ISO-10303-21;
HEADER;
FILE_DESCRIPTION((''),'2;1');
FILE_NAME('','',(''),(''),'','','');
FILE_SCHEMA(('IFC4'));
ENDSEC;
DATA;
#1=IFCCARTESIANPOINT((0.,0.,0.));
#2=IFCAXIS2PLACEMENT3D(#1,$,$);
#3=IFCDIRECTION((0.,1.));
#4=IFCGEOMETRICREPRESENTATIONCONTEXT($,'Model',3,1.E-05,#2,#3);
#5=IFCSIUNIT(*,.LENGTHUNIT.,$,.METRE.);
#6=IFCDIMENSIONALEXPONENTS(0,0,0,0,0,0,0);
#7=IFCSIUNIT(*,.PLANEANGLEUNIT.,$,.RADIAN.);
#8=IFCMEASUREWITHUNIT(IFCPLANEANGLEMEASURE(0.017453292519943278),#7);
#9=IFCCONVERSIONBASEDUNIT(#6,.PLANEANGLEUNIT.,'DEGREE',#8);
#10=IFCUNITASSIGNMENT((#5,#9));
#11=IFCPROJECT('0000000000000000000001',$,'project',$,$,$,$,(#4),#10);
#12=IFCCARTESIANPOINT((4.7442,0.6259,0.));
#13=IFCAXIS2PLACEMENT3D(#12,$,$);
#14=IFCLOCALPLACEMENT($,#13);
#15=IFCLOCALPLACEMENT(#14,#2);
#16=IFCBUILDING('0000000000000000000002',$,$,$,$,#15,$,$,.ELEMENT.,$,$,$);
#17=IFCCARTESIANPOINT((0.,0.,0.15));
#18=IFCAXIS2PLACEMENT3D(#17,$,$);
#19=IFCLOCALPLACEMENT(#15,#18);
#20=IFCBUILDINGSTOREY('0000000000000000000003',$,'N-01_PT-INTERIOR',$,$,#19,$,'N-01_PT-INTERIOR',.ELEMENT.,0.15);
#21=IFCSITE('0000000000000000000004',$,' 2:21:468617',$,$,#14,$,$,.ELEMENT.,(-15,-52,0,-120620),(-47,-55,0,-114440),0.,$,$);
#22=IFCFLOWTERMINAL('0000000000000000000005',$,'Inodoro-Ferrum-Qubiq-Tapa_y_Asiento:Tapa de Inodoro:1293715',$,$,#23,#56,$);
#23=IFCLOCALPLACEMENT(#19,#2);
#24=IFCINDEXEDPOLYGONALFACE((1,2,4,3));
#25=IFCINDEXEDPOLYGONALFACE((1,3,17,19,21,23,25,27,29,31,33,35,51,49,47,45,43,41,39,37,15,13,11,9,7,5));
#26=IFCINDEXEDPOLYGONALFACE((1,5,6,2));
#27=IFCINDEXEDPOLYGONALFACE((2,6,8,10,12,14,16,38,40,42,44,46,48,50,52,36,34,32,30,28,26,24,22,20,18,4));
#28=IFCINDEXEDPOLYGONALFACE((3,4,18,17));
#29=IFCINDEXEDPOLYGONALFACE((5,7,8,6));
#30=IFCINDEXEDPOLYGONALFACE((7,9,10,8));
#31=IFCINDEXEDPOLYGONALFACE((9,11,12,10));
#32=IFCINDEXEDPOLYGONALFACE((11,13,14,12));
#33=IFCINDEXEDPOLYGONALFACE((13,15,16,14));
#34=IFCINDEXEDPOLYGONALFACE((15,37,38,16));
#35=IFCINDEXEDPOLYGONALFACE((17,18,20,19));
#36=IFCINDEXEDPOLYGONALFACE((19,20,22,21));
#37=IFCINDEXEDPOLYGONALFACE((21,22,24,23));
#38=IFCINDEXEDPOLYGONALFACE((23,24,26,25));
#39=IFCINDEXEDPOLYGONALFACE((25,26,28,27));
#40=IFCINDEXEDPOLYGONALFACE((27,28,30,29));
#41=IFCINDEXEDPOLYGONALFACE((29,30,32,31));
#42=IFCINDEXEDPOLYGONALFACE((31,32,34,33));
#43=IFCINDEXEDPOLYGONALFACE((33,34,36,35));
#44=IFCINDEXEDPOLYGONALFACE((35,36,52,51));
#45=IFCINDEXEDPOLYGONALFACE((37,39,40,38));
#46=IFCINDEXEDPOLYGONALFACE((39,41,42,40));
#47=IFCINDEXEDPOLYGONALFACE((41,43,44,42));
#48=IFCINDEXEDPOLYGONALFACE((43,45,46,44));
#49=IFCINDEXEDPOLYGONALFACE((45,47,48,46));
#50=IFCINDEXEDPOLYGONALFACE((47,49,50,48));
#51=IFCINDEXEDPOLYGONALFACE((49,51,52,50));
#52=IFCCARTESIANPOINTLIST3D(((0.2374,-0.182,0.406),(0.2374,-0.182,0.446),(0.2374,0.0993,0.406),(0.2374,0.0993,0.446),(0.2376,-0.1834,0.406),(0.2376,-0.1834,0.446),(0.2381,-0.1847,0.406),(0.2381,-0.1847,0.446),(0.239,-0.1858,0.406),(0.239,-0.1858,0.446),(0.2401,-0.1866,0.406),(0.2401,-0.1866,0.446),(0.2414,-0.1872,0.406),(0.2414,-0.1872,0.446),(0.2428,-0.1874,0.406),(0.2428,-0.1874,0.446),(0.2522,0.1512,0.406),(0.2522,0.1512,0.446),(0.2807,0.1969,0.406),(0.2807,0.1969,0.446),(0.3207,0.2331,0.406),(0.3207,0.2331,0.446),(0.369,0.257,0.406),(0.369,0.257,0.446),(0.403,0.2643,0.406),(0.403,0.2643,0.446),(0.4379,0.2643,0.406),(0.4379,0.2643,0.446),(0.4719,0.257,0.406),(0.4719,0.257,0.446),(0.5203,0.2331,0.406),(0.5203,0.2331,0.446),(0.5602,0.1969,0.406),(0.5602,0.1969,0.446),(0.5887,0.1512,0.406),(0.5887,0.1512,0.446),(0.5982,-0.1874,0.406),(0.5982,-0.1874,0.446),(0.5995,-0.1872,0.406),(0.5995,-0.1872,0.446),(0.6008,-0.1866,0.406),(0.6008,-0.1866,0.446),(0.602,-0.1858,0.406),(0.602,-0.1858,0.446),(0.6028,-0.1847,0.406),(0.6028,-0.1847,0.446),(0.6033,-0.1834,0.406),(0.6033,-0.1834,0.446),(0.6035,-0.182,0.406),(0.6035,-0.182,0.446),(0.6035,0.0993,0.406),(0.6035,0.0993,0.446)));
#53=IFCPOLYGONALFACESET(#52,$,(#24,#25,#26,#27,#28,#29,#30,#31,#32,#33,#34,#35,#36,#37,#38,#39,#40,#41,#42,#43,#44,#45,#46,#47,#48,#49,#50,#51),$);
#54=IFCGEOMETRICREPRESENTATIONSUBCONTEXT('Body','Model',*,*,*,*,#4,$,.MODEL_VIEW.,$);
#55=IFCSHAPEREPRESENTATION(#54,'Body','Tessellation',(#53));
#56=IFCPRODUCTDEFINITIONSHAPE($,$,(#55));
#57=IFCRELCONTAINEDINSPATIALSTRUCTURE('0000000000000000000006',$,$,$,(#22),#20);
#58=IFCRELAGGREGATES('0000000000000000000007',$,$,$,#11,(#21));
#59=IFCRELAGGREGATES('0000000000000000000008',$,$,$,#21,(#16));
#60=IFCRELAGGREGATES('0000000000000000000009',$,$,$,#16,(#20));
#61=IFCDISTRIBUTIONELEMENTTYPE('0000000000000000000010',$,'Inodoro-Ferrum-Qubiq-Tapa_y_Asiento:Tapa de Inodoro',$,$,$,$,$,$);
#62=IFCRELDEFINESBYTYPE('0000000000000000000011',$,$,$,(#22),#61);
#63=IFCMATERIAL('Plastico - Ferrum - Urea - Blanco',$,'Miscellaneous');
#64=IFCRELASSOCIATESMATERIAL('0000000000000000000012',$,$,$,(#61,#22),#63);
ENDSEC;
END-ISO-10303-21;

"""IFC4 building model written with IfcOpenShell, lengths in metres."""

from ifc_helpers import new_model, entity, si_unit, converted_unit, direction, frame, origin, place, context, subcontext, project, spatial, line, arc, indexed_curve, outline, extrude, source, transform, mapped, material, type_object, type_shapes, element, save


model = new_model("IFC4")

# Units and contexts
model_context = context("Model", 3, precision=1e-05, world=origin(), true_north=direction((0.0, 1.0)))
body_context = subcontext(model_context, "Body", "Model", "MODEL_VIEW")
ifc_project = project(units=[si_unit("LENGTHUNIT", "METRE"), converted_unit("PLANEANGLEUNIT", "DEGREE", entity("IfcPlaneAngleMeasure", 0.017453292519943278), si_unit("PLANEANGLEUNIT", "RADIAN"), dimensions=[0, 0, 0, 0, 0, 0, 0])], contexts=[model_context])

# Site, building, storey
site_placement = place(None, frame((4.7442, 0.6259, 0.0)))
site = spatial("IfcSite", under=ifc_project, at=site_placement, Name=" 2:21:468617", CompositionType="ELEMENT", RefLatitude=(-15, -52, 0, -120620), RefLongitude=(-47, -55, 0, -114440), RefElevation=0.0)
building_placement = place(site_placement, origin())
building = spatial("IfcBuilding", under=site, at=building_placement, CompositionType="ELEMENT")
storey_placement = place(building_placement, frame((0.0, 0.0, 0.15)))
storey = spatial("IfcBuildingStorey", under=building, at=storey_placement, Name="N-01_PT-INTERIOR", LongName="N-01_PT-INTERIOR", CompositionType="ELEMENT", Elevation=0.15)

# Flow terminal
ifc_material = material(Name="Plastico - Ferrum - Urea - Blanco", Category="Miscellaneous")
distribution_element_type = type_object("IfcDistributionElementType", Name="Inodoro-Ferrum-Qubiq-Tapa_y_Asiento:Tapa de Inodoro", material=ifc_material)
shared_shape = source(origin(), body_context, "Body", "SweptSolid", [
    extrude(outline(indexed_curve([(-0.1787, -0.1831), (0.1026, -0.1831), (0.2002, -0.1397), (0.2602, -0.0514), (0.2685, 0.0), (0.2602, 0.0514), (0.2002, 0.1397), (0.1026, 0.1831), (-0.1787, 0.1831), (-0.1825, 0.1815), (-0.1841, 0.1777), (-0.1841, -0.1777), (-0.1825, -0.1815)], segments=[line(1, 2), arc(2, 3, 4), arc(4, 5, 6), arc(6, 7, 8), line(8, 9), arc(9, 10, 11), line(11, 12), arc(12, 13, 1)], self_intersect=False)), frame((0.0, -0.4295, 0.0), z_axis=(0.0, 0.0, 1.0), x_axis=(0.0, -1.0, 0.0)), (0.0, 0.0, 1.0), 0.04),
])
type_shapes(distribution_element_type, [shared_shape])
flow_terminal_placement = place(storey_placement, frame((0.4205, -0.4328, 0.406), z_axis=(0.0, 0.0, 1.0), x_axis=(-1.0, 0.0, 0.0)))
element("IfcFlowTerminal", 1, at=flow_terminal_placement, inside=storey, type_object=distribution_element_type, material=ifc_material, Name="Inodoro-Ferrum-Qubiq-Tapa_y_Asiento:Tapa de Inodoro:1293715", context=body_context, shape_type="MappedRepresentation", body=[
    mapped(shared_shape, transform((0.0, 0.0, 0.0), scale=1.0)),
])

save(model, "model.ifc")
